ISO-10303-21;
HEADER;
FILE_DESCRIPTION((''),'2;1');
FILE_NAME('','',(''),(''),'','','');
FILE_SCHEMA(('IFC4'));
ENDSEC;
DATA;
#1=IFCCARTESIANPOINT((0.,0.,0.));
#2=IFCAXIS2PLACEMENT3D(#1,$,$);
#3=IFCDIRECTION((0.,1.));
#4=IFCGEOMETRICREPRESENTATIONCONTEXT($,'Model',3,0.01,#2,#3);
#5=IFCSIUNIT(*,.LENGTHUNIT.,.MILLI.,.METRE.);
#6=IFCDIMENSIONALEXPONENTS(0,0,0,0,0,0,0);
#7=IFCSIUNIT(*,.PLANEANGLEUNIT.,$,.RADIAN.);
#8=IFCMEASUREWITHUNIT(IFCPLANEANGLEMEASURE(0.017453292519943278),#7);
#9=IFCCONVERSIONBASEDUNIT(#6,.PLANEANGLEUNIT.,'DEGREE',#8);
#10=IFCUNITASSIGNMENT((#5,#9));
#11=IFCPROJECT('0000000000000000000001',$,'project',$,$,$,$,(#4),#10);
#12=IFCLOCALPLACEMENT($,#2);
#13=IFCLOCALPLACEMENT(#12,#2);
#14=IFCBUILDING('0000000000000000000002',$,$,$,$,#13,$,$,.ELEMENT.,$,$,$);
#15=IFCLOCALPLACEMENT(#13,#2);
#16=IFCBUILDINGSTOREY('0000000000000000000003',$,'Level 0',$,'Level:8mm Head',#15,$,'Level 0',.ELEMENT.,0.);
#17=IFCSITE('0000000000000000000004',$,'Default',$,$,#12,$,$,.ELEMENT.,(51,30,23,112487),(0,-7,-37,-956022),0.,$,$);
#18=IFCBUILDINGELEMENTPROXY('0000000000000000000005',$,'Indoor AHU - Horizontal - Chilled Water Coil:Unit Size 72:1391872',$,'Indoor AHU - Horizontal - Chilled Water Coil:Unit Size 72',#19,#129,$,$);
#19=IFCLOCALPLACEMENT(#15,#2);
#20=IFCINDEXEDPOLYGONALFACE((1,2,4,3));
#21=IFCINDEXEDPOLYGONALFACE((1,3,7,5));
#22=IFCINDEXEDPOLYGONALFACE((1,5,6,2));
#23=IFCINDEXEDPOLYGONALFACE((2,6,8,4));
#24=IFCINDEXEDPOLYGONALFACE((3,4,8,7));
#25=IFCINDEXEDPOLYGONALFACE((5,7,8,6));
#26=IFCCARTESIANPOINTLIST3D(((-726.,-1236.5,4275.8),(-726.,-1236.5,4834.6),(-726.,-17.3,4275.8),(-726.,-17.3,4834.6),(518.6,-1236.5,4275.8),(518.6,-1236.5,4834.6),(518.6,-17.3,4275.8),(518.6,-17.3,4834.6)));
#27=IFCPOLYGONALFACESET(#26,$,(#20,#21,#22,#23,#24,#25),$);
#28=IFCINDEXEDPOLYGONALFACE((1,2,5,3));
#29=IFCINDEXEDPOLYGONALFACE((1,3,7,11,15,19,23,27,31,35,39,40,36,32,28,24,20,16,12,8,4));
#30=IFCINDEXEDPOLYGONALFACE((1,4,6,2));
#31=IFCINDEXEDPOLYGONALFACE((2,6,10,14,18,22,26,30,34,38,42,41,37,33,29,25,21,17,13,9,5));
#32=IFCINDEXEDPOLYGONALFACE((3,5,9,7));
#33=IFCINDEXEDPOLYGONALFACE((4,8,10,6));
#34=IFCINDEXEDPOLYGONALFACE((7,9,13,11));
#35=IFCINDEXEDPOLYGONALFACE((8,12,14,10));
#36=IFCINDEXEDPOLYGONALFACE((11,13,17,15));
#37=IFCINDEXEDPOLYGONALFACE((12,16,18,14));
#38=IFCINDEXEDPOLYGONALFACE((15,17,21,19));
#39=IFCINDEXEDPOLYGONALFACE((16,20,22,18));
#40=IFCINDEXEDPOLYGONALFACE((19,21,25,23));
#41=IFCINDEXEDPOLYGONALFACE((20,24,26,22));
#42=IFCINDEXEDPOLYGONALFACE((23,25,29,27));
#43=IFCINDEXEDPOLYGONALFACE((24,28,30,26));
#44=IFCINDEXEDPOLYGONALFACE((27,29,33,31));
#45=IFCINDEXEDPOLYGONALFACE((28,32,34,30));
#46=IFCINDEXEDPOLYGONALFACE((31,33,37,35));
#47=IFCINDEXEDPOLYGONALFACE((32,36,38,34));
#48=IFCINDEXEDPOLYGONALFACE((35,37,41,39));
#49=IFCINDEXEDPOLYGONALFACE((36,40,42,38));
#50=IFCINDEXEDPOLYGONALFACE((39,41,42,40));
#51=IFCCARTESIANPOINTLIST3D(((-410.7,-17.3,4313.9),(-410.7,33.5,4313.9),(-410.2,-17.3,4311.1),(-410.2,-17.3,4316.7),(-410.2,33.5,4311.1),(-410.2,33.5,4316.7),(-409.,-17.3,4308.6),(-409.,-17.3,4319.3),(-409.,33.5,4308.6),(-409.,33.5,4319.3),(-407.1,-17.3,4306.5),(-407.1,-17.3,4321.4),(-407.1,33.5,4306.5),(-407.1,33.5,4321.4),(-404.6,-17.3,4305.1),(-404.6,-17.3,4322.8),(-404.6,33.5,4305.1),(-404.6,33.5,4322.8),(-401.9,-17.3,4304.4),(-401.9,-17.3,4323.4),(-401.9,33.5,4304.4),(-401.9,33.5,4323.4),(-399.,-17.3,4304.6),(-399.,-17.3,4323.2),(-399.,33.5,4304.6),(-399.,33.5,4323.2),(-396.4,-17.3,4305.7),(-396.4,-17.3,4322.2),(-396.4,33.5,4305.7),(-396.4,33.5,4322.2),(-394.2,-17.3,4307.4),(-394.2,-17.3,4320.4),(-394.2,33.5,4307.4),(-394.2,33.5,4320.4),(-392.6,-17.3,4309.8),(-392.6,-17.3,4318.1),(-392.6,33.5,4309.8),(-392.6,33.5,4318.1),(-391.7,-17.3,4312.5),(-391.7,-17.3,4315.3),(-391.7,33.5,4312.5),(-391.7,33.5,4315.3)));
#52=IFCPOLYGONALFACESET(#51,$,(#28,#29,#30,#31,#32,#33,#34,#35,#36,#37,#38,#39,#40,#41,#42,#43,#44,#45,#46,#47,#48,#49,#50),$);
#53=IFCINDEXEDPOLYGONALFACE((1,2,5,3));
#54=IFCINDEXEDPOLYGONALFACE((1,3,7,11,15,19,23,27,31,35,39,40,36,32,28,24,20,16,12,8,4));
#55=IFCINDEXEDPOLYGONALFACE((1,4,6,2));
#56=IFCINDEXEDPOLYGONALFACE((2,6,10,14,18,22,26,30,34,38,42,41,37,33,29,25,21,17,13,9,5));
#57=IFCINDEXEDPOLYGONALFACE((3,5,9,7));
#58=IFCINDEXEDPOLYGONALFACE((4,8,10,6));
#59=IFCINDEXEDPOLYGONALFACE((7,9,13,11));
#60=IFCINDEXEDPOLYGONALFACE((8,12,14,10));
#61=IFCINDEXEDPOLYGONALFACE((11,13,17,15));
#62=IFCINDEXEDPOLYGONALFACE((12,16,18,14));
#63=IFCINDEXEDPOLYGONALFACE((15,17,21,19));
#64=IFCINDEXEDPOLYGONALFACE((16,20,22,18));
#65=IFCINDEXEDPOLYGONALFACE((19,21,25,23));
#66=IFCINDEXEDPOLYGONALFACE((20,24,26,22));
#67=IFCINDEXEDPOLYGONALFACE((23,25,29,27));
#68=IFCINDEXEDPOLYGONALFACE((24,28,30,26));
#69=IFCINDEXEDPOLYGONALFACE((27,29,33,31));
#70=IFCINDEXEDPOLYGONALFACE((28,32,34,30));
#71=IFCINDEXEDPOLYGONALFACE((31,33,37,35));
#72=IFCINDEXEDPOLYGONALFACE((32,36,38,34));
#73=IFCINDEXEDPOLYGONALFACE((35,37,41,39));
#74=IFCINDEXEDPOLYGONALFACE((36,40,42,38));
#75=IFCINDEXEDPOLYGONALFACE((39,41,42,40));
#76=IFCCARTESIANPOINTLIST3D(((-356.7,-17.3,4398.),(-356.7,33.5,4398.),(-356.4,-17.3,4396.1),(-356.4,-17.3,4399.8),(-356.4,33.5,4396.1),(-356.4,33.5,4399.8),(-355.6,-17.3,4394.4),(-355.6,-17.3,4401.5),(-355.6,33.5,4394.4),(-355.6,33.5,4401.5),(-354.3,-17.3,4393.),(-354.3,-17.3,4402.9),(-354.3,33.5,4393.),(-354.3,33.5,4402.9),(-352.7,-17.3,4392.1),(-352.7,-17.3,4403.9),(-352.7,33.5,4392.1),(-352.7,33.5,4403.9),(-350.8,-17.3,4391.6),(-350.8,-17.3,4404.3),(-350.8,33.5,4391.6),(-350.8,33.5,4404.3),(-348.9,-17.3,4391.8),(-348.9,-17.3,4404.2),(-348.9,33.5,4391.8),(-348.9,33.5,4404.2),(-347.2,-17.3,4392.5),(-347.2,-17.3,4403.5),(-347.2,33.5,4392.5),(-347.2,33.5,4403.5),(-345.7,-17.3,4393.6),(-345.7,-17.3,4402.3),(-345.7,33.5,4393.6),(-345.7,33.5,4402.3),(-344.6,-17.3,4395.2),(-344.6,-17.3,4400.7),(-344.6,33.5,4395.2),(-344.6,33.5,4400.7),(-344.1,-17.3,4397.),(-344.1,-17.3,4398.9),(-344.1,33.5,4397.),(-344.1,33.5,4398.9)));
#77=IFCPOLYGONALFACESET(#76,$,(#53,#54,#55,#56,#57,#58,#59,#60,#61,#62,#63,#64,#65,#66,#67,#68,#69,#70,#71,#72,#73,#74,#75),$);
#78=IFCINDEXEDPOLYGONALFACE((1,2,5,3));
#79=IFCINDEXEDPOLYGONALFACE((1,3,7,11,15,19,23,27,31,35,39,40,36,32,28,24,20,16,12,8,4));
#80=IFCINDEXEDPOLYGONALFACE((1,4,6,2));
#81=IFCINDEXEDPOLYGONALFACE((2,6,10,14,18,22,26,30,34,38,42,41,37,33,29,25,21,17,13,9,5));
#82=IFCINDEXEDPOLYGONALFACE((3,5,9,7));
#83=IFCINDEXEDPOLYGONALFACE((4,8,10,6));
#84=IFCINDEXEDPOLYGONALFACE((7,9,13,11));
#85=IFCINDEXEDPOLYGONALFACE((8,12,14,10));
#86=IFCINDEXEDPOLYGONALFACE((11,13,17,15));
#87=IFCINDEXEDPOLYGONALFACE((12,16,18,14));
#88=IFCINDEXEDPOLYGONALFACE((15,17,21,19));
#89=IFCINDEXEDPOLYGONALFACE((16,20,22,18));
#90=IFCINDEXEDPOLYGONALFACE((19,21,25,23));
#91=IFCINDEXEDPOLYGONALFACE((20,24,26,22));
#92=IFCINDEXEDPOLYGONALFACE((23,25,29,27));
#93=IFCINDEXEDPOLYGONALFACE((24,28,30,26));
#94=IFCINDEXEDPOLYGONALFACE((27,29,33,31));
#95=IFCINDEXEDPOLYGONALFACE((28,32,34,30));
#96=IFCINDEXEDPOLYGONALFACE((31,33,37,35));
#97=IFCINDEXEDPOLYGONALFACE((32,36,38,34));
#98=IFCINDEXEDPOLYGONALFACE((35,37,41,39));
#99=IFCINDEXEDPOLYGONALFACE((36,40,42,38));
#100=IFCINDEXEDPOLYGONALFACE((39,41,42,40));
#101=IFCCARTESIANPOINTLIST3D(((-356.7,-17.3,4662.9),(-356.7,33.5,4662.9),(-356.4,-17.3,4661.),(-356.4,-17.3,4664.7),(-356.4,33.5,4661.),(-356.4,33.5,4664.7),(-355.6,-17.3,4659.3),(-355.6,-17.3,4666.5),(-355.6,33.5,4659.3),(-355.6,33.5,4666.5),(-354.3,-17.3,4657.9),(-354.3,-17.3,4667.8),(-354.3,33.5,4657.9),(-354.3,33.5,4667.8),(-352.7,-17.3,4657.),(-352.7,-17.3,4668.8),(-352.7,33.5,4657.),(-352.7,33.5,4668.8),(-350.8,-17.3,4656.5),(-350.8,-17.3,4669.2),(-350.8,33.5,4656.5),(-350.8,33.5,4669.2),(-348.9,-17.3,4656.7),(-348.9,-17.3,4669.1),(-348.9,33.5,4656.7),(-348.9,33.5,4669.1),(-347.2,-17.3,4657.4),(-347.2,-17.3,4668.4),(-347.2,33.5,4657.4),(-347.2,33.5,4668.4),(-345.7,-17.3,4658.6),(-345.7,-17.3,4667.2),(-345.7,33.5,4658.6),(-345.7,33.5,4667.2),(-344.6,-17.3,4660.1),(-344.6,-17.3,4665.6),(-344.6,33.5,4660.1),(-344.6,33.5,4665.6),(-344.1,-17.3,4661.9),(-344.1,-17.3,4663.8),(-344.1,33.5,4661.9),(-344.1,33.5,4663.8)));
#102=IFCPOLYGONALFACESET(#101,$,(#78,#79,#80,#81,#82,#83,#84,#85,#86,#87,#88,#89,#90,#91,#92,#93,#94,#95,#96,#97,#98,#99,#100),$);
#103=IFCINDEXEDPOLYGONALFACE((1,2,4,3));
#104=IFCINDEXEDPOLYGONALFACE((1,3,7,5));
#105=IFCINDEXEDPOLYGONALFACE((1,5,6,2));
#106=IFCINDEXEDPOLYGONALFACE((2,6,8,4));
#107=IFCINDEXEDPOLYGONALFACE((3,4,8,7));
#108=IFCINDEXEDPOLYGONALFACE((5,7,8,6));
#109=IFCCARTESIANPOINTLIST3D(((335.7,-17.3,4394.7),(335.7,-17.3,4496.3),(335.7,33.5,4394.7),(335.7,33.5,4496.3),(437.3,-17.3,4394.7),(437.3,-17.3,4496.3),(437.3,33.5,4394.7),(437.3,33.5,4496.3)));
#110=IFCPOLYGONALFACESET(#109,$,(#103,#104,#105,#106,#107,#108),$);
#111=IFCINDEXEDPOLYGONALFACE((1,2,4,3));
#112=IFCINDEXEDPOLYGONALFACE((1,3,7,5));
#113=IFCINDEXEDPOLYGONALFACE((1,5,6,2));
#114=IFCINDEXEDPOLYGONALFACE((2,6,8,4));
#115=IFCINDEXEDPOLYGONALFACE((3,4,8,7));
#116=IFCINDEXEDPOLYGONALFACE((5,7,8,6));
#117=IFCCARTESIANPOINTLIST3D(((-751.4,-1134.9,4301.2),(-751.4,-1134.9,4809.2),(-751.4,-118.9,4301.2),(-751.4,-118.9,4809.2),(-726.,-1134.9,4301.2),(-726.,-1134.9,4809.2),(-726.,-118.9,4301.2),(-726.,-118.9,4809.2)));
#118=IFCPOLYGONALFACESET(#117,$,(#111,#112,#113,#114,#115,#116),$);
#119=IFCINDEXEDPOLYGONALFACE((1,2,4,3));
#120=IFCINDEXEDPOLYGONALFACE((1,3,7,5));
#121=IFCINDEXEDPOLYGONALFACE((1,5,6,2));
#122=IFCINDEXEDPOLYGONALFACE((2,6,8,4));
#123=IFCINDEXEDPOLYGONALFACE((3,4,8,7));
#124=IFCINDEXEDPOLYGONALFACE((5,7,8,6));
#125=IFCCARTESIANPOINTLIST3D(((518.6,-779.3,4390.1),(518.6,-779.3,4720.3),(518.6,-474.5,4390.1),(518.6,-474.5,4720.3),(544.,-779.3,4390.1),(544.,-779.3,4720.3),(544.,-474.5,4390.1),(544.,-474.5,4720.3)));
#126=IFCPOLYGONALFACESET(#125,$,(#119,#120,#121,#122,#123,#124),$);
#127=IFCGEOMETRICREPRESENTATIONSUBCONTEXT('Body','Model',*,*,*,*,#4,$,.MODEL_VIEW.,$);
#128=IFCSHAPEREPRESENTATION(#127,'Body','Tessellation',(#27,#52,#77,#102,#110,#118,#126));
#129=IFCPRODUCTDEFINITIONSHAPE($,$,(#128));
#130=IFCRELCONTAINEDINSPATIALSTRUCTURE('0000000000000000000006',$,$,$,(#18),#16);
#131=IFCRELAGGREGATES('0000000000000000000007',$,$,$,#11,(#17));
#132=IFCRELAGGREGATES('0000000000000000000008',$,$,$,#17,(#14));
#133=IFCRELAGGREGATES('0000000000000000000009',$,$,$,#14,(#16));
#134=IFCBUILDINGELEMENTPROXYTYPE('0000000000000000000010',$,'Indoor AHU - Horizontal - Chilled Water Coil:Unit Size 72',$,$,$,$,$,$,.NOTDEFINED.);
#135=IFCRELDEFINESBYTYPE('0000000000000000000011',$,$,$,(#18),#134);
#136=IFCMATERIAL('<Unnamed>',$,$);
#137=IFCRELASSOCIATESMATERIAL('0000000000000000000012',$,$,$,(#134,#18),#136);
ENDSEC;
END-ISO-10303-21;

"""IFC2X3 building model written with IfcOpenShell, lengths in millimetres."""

from ifc_helpers import new_model, entity, si_unit, converted_unit, direction, frame, frame_2d, origin, origin_2d_with_axis, place, context, subcontext, project, spatial, rectangle, circle, extrude, source, transform, mapped, material, type_object, type_shapes, element, save


model = new_model("IFC2X3")

# Units and contexts
model_context = context("Model", 3, precision=0.01, world=origin(), true_north=direction((0.0, 1.0)))
body_context = subcontext(model_context, "Body", "Model", "MODEL_VIEW")
ifc_project = project(units=[si_unit("LENGTHUNIT", "METRE", prefix="MILLI"), converted_unit("PLANEANGLEUNIT", "DEGREE", entity("IfcPlaneAngleMeasure", 0.017453292519943278), si_unit("PLANEANGLEUNIT", "RADIAN"), dimensions=[0, 0, 0, 0, 0, 0, 0])], contexts=[model_context])

# Site, building, storey
site_placement = place(None, origin())
site = spatial("IfcSite", under=ifc_project, at=site_placement, Name="Default", CompositionType="ELEMENT", RefLatitude=(51, 30, 23, 112487), RefLongitude=(0, -7, -37, -956022), RefElevation=0.0)
building_placement = place(site_placement, origin())
building = spatial("IfcBuilding", under=site, at=building_placement, CompositionType="ELEMENT")
storey_placement = place(building_placement, origin())
storey = spatial("IfcBuildingStorey", under=building, at=storey_placement, Name="Level 0", ObjectType="Level:8mm Head", LongName="Level 0", CompositionType="ELEMENT", Elevation=0.0)

# Shared definitions
ifc_material_1 = material(Name="<Unnamed>")

# Building element proxy
building_element_proxy_type = type_object("IfcBuildingElementProxyType", Name="Indoor AHU - Horizontal - Chilled Water Coil:Unit Size 72", PredefinedType="NOTDEFINED", material=ifc_material_1)
shared_shape_1 = source(origin(), body_context, "Body", "SweptSolid", [
    extrude(rectangle(XDim=1244.6, YDim=1219.2, at=origin_2d_with_axis()), frame((622.3, 609.6, 0.0), z_axis=(0.0, 0.0, 1.0), x_axis=(-1.0, 0.0, 0.0)), (0.0, 0.0, 1.0), 558.8),
    extrude(circle(Radius=9.5, at=frame_2d((0.0, 0.0), x_axis=(1.0, 0.0))), frame((919.7, -50.8, 38.1), z_axis=(0.0, 1.0, 0.0), x_axis=(1.0, 0.0, 0.0)), (0.0, 0.0, 1.0), 50.8),
    extrude(circle(Radius=6.4, at=frame_2d((0.0, 0.0), x_axis=(1.0, 0.0))), frame((868.9, -50.8, 122.1), z_axis=(0.0, 1.0, 0.0), x_axis=(1.0, 0.0, 0.0)), (0.0, 0.0, 1.0), 50.8),
    extrude(circle(Radius=6.4, at=frame_2d((0.0, 0.0), x_axis=(1.0, 0.0))), frame((868.9, -50.8, 387.1), z_axis=(0.0, 1.0, 0.0), x_axis=(1.0, 0.0, 0.0)), (0.0, 0.0, 1.0), 50.8),
    extrude(rectangle(XDim=50.8, YDim=101.6, at=frame_2d((0.0, 0.0), x_axis=(1.0, 0.0))), frame((132.1, -25.4, 118.9), z_axis=(0.0, 0.0, 1.0), x_axis=(0.0, 1.0, 0.0)), (0.0, 0.0, 1.0), 101.6),
    extrude(rectangle(XDim=25.4, YDim=1016.0, at=origin_2d_with_axis()), frame((1257.3, 609.6, 25.4), z_axis=(0.0, 0.0, 1.0), x_axis=(-1.0, 0.0, 0.0)), (0.0, 0.0, 1.0), 508.0),
    extrude(rectangle(XDim=25.4, YDim=304.8, at=frame_2d((0.0, 0.0), x_axis=(1.0, 0.0))), frame((-12.7, 609.6, 114.3), z_axis=(0.0, 0.0, 1.0), x_axis=(-1.0, 0.0, 0.0)), (0.0, 0.0, 1.0), 330.2),
])
type_shapes(building_element_proxy_type, [shared_shape_1])
proxy_placement = place(storey_placement, frame((518.6, -17.3, 4275.8), z_axis=(0.0, 0.0, 1.0), x_axis=(-1.0, 0.0, 0.0)))
element("IfcBuildingElementProxy", 1, at=proxy_placement, inside=storey, type_object=building_element_proxy_type, material=ifc_material_1, Name="Indoor AHU - Horizontal - Chilled Water Coil:Unit Size 72:1391872", ObjectType="Indoor AHU - Horizontal - Chilled Water Coil:Unit Size 72", context=body_context, shape_type="MappedRepresentation", body=[
    mapped(shared_shape_1, transform((0.0, 0.0, 0.0), scale=1.0)),
])

save(model, "model.ifc")
